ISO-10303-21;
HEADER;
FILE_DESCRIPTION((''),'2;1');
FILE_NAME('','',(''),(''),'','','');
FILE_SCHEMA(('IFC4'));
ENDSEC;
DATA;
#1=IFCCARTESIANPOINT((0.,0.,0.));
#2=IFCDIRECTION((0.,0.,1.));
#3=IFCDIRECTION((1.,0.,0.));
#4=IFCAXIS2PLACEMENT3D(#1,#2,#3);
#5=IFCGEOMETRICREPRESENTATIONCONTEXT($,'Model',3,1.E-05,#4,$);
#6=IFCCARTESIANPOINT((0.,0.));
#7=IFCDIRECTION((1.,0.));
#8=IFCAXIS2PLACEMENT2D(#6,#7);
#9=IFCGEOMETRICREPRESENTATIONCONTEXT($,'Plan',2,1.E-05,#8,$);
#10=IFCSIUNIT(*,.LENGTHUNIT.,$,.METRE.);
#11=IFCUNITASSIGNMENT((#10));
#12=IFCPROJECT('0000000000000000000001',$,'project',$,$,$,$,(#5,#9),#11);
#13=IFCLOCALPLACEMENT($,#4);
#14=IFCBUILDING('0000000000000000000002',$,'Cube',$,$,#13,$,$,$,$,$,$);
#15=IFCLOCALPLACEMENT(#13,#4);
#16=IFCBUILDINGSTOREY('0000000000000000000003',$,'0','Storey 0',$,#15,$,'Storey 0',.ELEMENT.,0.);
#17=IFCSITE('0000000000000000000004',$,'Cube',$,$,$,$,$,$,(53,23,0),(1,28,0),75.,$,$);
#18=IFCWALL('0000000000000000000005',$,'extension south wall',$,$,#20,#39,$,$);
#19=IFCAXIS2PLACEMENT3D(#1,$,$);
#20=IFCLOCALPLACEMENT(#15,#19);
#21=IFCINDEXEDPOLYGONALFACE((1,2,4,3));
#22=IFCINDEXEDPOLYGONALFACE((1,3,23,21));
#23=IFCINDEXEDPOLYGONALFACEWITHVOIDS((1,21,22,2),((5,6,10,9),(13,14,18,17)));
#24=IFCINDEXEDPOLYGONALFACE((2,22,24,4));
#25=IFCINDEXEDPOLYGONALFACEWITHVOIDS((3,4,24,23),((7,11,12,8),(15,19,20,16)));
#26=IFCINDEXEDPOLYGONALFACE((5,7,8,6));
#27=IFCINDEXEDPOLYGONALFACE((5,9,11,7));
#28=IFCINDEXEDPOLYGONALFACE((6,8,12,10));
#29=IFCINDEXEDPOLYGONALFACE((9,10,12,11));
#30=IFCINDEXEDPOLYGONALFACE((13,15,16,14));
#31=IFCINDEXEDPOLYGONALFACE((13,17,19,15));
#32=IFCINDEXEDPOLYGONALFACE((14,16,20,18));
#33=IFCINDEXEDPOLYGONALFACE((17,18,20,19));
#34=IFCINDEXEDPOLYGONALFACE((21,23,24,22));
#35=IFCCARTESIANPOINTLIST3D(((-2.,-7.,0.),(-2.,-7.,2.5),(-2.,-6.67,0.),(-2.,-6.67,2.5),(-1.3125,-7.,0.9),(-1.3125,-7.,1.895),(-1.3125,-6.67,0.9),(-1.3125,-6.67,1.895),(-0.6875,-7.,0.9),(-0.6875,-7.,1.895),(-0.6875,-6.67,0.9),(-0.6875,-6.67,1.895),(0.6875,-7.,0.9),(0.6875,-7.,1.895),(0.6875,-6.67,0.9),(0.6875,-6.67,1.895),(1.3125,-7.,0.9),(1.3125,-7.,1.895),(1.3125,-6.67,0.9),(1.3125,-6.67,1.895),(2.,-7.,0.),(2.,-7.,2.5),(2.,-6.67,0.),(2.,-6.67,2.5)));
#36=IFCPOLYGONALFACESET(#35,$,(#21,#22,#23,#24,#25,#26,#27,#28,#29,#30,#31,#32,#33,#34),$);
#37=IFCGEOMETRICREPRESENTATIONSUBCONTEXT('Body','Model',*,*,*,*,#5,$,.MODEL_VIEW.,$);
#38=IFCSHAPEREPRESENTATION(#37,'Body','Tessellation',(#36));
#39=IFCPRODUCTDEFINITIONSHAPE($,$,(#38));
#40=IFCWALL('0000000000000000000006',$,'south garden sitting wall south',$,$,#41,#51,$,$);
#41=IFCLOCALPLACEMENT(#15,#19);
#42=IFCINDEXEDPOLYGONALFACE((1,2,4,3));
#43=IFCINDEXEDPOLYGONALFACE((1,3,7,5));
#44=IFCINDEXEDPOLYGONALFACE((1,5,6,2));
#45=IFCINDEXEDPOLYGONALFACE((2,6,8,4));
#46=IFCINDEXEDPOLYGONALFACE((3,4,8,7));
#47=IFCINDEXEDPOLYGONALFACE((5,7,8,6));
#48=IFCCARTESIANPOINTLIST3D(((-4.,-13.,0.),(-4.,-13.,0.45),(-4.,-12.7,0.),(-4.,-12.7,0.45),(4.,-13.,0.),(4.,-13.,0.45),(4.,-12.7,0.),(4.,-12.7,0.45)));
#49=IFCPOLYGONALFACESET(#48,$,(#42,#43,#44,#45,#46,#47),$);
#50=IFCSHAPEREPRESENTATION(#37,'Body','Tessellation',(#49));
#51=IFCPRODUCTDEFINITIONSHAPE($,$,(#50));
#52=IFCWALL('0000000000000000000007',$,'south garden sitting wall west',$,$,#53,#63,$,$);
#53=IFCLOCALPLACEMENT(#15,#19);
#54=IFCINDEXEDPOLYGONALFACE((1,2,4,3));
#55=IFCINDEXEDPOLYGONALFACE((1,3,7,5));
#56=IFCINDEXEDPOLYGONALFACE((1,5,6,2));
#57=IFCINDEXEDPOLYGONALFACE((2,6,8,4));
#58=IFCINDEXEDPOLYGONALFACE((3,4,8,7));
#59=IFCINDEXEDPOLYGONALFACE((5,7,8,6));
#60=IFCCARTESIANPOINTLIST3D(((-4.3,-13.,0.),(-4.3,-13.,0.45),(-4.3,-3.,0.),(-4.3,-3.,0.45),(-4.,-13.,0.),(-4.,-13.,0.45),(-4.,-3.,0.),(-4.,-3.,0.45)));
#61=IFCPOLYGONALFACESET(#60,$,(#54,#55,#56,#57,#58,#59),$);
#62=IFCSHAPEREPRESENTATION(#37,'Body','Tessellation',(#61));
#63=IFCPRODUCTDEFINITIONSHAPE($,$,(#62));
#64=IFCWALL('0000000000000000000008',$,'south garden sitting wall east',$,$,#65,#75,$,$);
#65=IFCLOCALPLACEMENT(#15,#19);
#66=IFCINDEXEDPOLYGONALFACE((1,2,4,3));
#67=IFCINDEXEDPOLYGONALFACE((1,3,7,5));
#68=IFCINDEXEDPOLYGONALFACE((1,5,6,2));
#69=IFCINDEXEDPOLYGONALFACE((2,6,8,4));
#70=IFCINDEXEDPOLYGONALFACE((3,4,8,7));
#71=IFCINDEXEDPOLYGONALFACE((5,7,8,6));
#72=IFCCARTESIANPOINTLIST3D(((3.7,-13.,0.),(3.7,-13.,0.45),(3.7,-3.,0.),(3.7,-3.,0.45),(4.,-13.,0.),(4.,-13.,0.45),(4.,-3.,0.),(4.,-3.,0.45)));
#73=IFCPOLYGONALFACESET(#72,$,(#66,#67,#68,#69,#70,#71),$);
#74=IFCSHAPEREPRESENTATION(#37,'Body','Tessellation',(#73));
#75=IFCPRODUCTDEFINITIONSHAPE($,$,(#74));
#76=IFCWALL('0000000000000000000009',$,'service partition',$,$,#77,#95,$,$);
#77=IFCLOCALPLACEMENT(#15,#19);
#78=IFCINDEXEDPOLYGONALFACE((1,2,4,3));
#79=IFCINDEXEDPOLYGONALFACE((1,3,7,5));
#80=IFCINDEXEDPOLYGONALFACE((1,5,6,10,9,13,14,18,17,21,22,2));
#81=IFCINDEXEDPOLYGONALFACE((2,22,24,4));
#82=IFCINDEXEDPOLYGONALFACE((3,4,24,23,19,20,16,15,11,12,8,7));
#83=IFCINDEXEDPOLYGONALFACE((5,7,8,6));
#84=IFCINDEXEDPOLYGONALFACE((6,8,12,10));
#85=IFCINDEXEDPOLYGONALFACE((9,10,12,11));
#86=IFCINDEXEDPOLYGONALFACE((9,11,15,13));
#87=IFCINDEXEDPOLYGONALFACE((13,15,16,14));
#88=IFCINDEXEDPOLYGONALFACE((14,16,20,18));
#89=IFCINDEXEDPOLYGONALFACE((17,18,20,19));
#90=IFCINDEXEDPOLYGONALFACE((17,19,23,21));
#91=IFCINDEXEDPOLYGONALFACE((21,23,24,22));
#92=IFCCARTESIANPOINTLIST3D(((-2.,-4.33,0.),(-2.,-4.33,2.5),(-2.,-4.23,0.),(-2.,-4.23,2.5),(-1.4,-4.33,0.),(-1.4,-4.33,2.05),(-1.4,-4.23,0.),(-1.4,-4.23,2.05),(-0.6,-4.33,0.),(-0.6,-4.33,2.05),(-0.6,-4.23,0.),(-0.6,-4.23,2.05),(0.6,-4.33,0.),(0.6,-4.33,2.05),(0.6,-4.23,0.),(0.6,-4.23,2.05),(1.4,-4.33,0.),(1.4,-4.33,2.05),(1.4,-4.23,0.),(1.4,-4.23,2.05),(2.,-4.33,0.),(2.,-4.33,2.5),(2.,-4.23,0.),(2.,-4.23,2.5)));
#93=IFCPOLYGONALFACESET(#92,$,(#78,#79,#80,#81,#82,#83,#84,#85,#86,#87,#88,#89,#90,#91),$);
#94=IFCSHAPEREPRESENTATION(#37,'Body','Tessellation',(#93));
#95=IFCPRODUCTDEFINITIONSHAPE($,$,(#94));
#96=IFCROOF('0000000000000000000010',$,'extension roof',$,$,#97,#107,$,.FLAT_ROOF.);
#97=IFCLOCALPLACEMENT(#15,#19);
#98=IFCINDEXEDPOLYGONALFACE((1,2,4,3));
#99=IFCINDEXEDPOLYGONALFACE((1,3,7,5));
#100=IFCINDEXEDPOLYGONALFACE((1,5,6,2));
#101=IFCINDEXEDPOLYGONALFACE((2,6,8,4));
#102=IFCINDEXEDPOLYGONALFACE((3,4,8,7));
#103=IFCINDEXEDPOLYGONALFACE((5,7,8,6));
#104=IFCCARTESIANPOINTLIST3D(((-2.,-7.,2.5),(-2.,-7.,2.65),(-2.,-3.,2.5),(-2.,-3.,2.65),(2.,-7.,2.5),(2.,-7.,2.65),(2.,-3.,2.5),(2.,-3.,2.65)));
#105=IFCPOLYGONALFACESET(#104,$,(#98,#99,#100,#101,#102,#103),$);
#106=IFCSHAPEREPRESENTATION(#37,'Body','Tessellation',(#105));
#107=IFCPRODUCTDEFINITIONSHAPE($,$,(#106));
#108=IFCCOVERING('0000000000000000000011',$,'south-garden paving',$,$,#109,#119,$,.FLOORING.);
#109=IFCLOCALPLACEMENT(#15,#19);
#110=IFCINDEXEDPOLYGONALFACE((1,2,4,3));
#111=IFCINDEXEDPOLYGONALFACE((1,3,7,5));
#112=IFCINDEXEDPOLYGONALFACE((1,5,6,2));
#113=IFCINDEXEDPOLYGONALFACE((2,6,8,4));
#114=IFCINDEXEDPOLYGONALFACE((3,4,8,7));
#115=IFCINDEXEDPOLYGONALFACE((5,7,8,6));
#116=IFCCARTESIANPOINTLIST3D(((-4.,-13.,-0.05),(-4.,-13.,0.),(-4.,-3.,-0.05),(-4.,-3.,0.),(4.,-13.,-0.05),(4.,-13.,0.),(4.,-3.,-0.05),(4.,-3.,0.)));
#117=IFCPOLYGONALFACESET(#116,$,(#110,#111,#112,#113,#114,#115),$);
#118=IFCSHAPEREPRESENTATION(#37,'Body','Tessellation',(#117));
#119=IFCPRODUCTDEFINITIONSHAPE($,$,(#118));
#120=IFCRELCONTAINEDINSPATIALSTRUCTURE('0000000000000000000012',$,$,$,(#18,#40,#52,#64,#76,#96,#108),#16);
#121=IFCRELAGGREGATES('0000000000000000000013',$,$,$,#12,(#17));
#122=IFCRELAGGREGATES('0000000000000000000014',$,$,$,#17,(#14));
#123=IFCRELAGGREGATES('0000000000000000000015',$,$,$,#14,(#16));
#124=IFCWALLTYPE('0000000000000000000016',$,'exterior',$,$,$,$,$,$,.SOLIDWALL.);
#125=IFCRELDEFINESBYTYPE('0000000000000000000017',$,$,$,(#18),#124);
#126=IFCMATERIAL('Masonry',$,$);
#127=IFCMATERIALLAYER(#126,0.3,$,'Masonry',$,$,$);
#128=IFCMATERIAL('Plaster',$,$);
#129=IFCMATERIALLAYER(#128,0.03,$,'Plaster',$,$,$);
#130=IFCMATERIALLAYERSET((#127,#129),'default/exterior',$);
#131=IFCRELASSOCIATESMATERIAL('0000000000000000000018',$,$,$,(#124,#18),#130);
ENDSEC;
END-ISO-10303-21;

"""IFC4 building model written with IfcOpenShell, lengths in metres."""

from ifc_helpers import new_model, si_unit, frame, origin_with_axes, origin_2d_with_axis, place, context, subcontext, project, spatial, indexed_curve, outline, extrude, material, layer, layer_set, layer_usage, type_object, element, save


model = new_model("IFC4")

# Units and contexts
model_context = context("Model", 3, precision=1e-05, world=origin_with_axes())
plan_context = context("Plan", 2, precision=1e-05, world=origin_2d_with_axis())
body_context_1 = subcontext(model_context, "Body", "Model", "MODEL_VIEW")
ifc_project = project(units=[si_unit("LENGTHUNIT", "METRE")], contexts=[model_context, plan_context])

# Site, building, storey
site = spatial("IfcSite", under=ifc_project, Name="Cube", RefLatitude=(53, 23, 0), RefLongitude=(1, 28, 0), RefElevation=75.0)
building_placement = place(None, origin_with_axes())
building = spatial("IfcBuilding", under=site, at=building_placement, Name="Cube")
storey_placement = place(building_placement, origin_with_axes())
storey = spatial("IfcBuildingStorey", under=building, at=storey_placement, Name="0", Description="Storey 0", LongName="Storey 0", CompositionType="ELEMENT", Elevation=0.0)

# Wall, openings
ifc_material_1 = material(Name="Masonry")
ifc_layer_1 = layer(ifc_material_1, 0.3, Name="Masonry")
ifc_material_2 = material(Name="Plaster")
ifc_layer_2 = layer(ifc_material_2, 0.03, Name="Plaster")
ifc_layer_set = layer_set([ifc_layer_1, ifc_layer_2], Name="default/exterior")
ifc_layer_usage = layer_usage(ifc_layer_set, "AXIS2", "POSITIVE", 0.0)
wall_type = type_object("IfcWallType", Name="exterior", PredefinedType="SOLIDWALL", material=ifc_layer_set)
wall_1_placement = place(storey_placement, frame((-2.0, -7.0, 0.0), z_axis=(0.0, 0.0, 1.0), x_axis=(1.0, 0.0, 0.0)))
wall_1 = element("IfcWall", 1, at=wall_1_placement, inside=storey, type_object=wall_type, material=ifc_layer_usage, Name="extension south wall", context=body_context_1, shape_type="SweptSolid", body=[
    extrude(outline(indexed_curve([(0.0, 0.0), (0.0, 0.33), (4.0, 0.33), (4.0, 0.0), (0.0, 0.0)], self_intersect=False)), origin_with_axes(), (0.0, 0.0, 1.0), 2.5),
])
opening_1_placement = place(wall_1_placement, frame((0.6875, 0.0, 0.9), z_axis=(0.0, 0.0, 1.0), x_axis=(1.0, 0.0, 0.0)))
element("IfcOpeningElement", 2, at=opening_1_placement, cuts=wall_1, PredefinedType="OPENING", context=body_context_1, shape_type="SweptSolid", body=[
    extrude(outline(indexed_curve([(0.0, 0.0), (0.0, 0.5), (0.625, 0.5), (0.625, 0.0), (0.0, 0.0)], self_intersect=False)), origin_with_axes(), (0.0, 0.0, 1.0), 0.995),
])
opening_2_placement = place(wall_1_placement, frame((2.6875, 0.0, 0.9), z_axis=(0.0, 0.0, 1.0), x_axis=(1.0, 0.0, 0.0)))
element("IfcOpeningElement", 3, at=opening_2_placement, cuts=wall_1, PredefinedType="OPENING", context=body_context_1, shape_type="SweptSolid", body=[
    extrude(outline(indexed_curve([(0.0, 0.0), (0.0, 0.5), (0.625, 0.5), (0.625, 0.0), (0.0, 0.0)], self_intersect=False)), origin_with_axes(), (0.0, 0.0, 1.0), 0.995),
])

# Walls
wall_2_placement = place(storey_placement, frame((-4.0, -13.0, 0.0), z_axis=(0.0, 0.0, 1.0), x_axis=(1.0, 0.0, 0.0)))
element("IfcWall", 4, at=wall_2_placement, inside=storey, Name="south garden sitting wall south", context=body_context_1, shape_type="SweptSolid", body=[
    extrude(outline(indexed_curve([(0.0, 0.0), (0.0, 0.3), (8.0, 0.3), (8.0, 0.0), (0.0, 0.0)], self_intersect=False)), origin_with_axes(), (0.0, 0.0, 1.0), 0.45),
])
for number, where, z_axis, x_axis, name in (
    (5, (-4.0, -13.0, 0.0), (0.0, 0.0, 1.0), (0.0, 1.0, 0.0), "south garden sitting wall west"),
    (6, (4.0, -13.0, 0.0), (0.0, 0.0, 1.0), (0.0, 1.0, 0.0), "south garden sitting wall east"),
):
    element("IfcWall", number, at=place(storey_placement, frame(where, z_axis=z_axis, x_axis=x_axis)), inside=storey, Name=name, context=body_context_1, shape_type="SweptSolid", body=[
        extrude(outline(indexed_curve([(0.0, 0.0), (0.0, 0.3), (10.0, 0.3), (10.0, 0.0), (0.0, 0.0)], self_intersect=False)), origin_with_axes(), (0.0, 0.0, 1.0), 0.45),
    ])

# Wall, openings
wall_3_placement = place(storey_placement, frame((-2.0, -4.33, 0.0), z_axis=(0.0, 0.0, 1.0), x_axis=(1.0, 0.0, 0.0)))
wall_3 = element("IfcWall", 7, at=wall_3_placement, inside=storey, Name="service partition", context=body_context_1, shape_type="SweptSolid", body=[
    extrude(outline(indexed_curve([(0.0, 0.0), (0.0, 0.1), (4.0, 0.1), (4.0, 0.0), (0.0, 0.0)], self_intersect=False)), origin_with_axes(), (0.0, 0.0, 1.0), 2.5),
])
opening_3_placement = place(wall_3_placement, frame((0.6, -0.05, 0.0), z_axis=(0.0, 0.0, 1.0), x_axis=(1.0, 0.0, 0.0)))
element("IfcOpeningElement", 8, at=opening_3_placement, cuts=wall_3, context=body_context_1, shape_type="SweptSolid", body=[
    extrude(outline(indexed_curve([(0.0, 0.0), (0.0, 0.3), (0.8, 0.3), (0.8, 0.0), (0.0, 0.0)], self_intersect=False)), origin_with_axes(), (0.0, 0.0, 1.0), 2.05),
])
opening_4_placement = place(wall_3_placement, frame((2.6, -0.05, 0.0), z_axis=(0.0, 0.0, 1.0), x_axis=(1.0, 0.0, 0.0)))
element("IfcOpeningElement", 9, at=opening_4_placement, cuts=wall_3, context=body_context_1, shape_type="SweptSolid", body=[
    extrude(outline(indexed_curve([(0.0, 0.0), (0.0, 0.3), (0.8, 0.3), (0.8, 0.0), (0.0, 0.0)], self_intersect=False)), origin_with_axes(), (0.0, 0.0, 1.0), 2.05),
])

# Roof
roof_placement = place(storey_placement, frame((-2.0, -7.0, 2.5), z_axis=(0.0, 0.0, 1.0), x_axis=(1.0, 0.0, 0.0)))
element("IfcRoof", 10, at=roof_placement, inside=storey, Name="extension roof", PredefinedType="FLAT_ROOF", context=body_context_1, shape_type="SweptSolid", body=[
    extrude(outline(indexed_curve([(0.0, 0.0), (4.0, 0.0), (4.0, 4.0), (0.0, 4.0)])), None, (0.0, 0.0, 1.0), 0.15),
])

# Covering
covering_placement = place(storey_placement, frame((-4.0, -13.0, 0.0), z_axis=(0.0, 0.0, 1.0), x_axis=(1.0, 0.0, 0.0)))
element("IfcCovering", 11, at=covering_placement, inside=storey, Name="south-garden paving", PredefinedType="FLOORING", context=body_context_1, shape_type="SweptSolid", body=[
    extrude(outline(indexed_curve([(0.0, 0.0), (8.0, 0.0), (8.0, 10.0), (0.0, 10.0)])), None, (0.0, 0.0, -1.0), 0.05),
])

save(model, "model.ifc")
